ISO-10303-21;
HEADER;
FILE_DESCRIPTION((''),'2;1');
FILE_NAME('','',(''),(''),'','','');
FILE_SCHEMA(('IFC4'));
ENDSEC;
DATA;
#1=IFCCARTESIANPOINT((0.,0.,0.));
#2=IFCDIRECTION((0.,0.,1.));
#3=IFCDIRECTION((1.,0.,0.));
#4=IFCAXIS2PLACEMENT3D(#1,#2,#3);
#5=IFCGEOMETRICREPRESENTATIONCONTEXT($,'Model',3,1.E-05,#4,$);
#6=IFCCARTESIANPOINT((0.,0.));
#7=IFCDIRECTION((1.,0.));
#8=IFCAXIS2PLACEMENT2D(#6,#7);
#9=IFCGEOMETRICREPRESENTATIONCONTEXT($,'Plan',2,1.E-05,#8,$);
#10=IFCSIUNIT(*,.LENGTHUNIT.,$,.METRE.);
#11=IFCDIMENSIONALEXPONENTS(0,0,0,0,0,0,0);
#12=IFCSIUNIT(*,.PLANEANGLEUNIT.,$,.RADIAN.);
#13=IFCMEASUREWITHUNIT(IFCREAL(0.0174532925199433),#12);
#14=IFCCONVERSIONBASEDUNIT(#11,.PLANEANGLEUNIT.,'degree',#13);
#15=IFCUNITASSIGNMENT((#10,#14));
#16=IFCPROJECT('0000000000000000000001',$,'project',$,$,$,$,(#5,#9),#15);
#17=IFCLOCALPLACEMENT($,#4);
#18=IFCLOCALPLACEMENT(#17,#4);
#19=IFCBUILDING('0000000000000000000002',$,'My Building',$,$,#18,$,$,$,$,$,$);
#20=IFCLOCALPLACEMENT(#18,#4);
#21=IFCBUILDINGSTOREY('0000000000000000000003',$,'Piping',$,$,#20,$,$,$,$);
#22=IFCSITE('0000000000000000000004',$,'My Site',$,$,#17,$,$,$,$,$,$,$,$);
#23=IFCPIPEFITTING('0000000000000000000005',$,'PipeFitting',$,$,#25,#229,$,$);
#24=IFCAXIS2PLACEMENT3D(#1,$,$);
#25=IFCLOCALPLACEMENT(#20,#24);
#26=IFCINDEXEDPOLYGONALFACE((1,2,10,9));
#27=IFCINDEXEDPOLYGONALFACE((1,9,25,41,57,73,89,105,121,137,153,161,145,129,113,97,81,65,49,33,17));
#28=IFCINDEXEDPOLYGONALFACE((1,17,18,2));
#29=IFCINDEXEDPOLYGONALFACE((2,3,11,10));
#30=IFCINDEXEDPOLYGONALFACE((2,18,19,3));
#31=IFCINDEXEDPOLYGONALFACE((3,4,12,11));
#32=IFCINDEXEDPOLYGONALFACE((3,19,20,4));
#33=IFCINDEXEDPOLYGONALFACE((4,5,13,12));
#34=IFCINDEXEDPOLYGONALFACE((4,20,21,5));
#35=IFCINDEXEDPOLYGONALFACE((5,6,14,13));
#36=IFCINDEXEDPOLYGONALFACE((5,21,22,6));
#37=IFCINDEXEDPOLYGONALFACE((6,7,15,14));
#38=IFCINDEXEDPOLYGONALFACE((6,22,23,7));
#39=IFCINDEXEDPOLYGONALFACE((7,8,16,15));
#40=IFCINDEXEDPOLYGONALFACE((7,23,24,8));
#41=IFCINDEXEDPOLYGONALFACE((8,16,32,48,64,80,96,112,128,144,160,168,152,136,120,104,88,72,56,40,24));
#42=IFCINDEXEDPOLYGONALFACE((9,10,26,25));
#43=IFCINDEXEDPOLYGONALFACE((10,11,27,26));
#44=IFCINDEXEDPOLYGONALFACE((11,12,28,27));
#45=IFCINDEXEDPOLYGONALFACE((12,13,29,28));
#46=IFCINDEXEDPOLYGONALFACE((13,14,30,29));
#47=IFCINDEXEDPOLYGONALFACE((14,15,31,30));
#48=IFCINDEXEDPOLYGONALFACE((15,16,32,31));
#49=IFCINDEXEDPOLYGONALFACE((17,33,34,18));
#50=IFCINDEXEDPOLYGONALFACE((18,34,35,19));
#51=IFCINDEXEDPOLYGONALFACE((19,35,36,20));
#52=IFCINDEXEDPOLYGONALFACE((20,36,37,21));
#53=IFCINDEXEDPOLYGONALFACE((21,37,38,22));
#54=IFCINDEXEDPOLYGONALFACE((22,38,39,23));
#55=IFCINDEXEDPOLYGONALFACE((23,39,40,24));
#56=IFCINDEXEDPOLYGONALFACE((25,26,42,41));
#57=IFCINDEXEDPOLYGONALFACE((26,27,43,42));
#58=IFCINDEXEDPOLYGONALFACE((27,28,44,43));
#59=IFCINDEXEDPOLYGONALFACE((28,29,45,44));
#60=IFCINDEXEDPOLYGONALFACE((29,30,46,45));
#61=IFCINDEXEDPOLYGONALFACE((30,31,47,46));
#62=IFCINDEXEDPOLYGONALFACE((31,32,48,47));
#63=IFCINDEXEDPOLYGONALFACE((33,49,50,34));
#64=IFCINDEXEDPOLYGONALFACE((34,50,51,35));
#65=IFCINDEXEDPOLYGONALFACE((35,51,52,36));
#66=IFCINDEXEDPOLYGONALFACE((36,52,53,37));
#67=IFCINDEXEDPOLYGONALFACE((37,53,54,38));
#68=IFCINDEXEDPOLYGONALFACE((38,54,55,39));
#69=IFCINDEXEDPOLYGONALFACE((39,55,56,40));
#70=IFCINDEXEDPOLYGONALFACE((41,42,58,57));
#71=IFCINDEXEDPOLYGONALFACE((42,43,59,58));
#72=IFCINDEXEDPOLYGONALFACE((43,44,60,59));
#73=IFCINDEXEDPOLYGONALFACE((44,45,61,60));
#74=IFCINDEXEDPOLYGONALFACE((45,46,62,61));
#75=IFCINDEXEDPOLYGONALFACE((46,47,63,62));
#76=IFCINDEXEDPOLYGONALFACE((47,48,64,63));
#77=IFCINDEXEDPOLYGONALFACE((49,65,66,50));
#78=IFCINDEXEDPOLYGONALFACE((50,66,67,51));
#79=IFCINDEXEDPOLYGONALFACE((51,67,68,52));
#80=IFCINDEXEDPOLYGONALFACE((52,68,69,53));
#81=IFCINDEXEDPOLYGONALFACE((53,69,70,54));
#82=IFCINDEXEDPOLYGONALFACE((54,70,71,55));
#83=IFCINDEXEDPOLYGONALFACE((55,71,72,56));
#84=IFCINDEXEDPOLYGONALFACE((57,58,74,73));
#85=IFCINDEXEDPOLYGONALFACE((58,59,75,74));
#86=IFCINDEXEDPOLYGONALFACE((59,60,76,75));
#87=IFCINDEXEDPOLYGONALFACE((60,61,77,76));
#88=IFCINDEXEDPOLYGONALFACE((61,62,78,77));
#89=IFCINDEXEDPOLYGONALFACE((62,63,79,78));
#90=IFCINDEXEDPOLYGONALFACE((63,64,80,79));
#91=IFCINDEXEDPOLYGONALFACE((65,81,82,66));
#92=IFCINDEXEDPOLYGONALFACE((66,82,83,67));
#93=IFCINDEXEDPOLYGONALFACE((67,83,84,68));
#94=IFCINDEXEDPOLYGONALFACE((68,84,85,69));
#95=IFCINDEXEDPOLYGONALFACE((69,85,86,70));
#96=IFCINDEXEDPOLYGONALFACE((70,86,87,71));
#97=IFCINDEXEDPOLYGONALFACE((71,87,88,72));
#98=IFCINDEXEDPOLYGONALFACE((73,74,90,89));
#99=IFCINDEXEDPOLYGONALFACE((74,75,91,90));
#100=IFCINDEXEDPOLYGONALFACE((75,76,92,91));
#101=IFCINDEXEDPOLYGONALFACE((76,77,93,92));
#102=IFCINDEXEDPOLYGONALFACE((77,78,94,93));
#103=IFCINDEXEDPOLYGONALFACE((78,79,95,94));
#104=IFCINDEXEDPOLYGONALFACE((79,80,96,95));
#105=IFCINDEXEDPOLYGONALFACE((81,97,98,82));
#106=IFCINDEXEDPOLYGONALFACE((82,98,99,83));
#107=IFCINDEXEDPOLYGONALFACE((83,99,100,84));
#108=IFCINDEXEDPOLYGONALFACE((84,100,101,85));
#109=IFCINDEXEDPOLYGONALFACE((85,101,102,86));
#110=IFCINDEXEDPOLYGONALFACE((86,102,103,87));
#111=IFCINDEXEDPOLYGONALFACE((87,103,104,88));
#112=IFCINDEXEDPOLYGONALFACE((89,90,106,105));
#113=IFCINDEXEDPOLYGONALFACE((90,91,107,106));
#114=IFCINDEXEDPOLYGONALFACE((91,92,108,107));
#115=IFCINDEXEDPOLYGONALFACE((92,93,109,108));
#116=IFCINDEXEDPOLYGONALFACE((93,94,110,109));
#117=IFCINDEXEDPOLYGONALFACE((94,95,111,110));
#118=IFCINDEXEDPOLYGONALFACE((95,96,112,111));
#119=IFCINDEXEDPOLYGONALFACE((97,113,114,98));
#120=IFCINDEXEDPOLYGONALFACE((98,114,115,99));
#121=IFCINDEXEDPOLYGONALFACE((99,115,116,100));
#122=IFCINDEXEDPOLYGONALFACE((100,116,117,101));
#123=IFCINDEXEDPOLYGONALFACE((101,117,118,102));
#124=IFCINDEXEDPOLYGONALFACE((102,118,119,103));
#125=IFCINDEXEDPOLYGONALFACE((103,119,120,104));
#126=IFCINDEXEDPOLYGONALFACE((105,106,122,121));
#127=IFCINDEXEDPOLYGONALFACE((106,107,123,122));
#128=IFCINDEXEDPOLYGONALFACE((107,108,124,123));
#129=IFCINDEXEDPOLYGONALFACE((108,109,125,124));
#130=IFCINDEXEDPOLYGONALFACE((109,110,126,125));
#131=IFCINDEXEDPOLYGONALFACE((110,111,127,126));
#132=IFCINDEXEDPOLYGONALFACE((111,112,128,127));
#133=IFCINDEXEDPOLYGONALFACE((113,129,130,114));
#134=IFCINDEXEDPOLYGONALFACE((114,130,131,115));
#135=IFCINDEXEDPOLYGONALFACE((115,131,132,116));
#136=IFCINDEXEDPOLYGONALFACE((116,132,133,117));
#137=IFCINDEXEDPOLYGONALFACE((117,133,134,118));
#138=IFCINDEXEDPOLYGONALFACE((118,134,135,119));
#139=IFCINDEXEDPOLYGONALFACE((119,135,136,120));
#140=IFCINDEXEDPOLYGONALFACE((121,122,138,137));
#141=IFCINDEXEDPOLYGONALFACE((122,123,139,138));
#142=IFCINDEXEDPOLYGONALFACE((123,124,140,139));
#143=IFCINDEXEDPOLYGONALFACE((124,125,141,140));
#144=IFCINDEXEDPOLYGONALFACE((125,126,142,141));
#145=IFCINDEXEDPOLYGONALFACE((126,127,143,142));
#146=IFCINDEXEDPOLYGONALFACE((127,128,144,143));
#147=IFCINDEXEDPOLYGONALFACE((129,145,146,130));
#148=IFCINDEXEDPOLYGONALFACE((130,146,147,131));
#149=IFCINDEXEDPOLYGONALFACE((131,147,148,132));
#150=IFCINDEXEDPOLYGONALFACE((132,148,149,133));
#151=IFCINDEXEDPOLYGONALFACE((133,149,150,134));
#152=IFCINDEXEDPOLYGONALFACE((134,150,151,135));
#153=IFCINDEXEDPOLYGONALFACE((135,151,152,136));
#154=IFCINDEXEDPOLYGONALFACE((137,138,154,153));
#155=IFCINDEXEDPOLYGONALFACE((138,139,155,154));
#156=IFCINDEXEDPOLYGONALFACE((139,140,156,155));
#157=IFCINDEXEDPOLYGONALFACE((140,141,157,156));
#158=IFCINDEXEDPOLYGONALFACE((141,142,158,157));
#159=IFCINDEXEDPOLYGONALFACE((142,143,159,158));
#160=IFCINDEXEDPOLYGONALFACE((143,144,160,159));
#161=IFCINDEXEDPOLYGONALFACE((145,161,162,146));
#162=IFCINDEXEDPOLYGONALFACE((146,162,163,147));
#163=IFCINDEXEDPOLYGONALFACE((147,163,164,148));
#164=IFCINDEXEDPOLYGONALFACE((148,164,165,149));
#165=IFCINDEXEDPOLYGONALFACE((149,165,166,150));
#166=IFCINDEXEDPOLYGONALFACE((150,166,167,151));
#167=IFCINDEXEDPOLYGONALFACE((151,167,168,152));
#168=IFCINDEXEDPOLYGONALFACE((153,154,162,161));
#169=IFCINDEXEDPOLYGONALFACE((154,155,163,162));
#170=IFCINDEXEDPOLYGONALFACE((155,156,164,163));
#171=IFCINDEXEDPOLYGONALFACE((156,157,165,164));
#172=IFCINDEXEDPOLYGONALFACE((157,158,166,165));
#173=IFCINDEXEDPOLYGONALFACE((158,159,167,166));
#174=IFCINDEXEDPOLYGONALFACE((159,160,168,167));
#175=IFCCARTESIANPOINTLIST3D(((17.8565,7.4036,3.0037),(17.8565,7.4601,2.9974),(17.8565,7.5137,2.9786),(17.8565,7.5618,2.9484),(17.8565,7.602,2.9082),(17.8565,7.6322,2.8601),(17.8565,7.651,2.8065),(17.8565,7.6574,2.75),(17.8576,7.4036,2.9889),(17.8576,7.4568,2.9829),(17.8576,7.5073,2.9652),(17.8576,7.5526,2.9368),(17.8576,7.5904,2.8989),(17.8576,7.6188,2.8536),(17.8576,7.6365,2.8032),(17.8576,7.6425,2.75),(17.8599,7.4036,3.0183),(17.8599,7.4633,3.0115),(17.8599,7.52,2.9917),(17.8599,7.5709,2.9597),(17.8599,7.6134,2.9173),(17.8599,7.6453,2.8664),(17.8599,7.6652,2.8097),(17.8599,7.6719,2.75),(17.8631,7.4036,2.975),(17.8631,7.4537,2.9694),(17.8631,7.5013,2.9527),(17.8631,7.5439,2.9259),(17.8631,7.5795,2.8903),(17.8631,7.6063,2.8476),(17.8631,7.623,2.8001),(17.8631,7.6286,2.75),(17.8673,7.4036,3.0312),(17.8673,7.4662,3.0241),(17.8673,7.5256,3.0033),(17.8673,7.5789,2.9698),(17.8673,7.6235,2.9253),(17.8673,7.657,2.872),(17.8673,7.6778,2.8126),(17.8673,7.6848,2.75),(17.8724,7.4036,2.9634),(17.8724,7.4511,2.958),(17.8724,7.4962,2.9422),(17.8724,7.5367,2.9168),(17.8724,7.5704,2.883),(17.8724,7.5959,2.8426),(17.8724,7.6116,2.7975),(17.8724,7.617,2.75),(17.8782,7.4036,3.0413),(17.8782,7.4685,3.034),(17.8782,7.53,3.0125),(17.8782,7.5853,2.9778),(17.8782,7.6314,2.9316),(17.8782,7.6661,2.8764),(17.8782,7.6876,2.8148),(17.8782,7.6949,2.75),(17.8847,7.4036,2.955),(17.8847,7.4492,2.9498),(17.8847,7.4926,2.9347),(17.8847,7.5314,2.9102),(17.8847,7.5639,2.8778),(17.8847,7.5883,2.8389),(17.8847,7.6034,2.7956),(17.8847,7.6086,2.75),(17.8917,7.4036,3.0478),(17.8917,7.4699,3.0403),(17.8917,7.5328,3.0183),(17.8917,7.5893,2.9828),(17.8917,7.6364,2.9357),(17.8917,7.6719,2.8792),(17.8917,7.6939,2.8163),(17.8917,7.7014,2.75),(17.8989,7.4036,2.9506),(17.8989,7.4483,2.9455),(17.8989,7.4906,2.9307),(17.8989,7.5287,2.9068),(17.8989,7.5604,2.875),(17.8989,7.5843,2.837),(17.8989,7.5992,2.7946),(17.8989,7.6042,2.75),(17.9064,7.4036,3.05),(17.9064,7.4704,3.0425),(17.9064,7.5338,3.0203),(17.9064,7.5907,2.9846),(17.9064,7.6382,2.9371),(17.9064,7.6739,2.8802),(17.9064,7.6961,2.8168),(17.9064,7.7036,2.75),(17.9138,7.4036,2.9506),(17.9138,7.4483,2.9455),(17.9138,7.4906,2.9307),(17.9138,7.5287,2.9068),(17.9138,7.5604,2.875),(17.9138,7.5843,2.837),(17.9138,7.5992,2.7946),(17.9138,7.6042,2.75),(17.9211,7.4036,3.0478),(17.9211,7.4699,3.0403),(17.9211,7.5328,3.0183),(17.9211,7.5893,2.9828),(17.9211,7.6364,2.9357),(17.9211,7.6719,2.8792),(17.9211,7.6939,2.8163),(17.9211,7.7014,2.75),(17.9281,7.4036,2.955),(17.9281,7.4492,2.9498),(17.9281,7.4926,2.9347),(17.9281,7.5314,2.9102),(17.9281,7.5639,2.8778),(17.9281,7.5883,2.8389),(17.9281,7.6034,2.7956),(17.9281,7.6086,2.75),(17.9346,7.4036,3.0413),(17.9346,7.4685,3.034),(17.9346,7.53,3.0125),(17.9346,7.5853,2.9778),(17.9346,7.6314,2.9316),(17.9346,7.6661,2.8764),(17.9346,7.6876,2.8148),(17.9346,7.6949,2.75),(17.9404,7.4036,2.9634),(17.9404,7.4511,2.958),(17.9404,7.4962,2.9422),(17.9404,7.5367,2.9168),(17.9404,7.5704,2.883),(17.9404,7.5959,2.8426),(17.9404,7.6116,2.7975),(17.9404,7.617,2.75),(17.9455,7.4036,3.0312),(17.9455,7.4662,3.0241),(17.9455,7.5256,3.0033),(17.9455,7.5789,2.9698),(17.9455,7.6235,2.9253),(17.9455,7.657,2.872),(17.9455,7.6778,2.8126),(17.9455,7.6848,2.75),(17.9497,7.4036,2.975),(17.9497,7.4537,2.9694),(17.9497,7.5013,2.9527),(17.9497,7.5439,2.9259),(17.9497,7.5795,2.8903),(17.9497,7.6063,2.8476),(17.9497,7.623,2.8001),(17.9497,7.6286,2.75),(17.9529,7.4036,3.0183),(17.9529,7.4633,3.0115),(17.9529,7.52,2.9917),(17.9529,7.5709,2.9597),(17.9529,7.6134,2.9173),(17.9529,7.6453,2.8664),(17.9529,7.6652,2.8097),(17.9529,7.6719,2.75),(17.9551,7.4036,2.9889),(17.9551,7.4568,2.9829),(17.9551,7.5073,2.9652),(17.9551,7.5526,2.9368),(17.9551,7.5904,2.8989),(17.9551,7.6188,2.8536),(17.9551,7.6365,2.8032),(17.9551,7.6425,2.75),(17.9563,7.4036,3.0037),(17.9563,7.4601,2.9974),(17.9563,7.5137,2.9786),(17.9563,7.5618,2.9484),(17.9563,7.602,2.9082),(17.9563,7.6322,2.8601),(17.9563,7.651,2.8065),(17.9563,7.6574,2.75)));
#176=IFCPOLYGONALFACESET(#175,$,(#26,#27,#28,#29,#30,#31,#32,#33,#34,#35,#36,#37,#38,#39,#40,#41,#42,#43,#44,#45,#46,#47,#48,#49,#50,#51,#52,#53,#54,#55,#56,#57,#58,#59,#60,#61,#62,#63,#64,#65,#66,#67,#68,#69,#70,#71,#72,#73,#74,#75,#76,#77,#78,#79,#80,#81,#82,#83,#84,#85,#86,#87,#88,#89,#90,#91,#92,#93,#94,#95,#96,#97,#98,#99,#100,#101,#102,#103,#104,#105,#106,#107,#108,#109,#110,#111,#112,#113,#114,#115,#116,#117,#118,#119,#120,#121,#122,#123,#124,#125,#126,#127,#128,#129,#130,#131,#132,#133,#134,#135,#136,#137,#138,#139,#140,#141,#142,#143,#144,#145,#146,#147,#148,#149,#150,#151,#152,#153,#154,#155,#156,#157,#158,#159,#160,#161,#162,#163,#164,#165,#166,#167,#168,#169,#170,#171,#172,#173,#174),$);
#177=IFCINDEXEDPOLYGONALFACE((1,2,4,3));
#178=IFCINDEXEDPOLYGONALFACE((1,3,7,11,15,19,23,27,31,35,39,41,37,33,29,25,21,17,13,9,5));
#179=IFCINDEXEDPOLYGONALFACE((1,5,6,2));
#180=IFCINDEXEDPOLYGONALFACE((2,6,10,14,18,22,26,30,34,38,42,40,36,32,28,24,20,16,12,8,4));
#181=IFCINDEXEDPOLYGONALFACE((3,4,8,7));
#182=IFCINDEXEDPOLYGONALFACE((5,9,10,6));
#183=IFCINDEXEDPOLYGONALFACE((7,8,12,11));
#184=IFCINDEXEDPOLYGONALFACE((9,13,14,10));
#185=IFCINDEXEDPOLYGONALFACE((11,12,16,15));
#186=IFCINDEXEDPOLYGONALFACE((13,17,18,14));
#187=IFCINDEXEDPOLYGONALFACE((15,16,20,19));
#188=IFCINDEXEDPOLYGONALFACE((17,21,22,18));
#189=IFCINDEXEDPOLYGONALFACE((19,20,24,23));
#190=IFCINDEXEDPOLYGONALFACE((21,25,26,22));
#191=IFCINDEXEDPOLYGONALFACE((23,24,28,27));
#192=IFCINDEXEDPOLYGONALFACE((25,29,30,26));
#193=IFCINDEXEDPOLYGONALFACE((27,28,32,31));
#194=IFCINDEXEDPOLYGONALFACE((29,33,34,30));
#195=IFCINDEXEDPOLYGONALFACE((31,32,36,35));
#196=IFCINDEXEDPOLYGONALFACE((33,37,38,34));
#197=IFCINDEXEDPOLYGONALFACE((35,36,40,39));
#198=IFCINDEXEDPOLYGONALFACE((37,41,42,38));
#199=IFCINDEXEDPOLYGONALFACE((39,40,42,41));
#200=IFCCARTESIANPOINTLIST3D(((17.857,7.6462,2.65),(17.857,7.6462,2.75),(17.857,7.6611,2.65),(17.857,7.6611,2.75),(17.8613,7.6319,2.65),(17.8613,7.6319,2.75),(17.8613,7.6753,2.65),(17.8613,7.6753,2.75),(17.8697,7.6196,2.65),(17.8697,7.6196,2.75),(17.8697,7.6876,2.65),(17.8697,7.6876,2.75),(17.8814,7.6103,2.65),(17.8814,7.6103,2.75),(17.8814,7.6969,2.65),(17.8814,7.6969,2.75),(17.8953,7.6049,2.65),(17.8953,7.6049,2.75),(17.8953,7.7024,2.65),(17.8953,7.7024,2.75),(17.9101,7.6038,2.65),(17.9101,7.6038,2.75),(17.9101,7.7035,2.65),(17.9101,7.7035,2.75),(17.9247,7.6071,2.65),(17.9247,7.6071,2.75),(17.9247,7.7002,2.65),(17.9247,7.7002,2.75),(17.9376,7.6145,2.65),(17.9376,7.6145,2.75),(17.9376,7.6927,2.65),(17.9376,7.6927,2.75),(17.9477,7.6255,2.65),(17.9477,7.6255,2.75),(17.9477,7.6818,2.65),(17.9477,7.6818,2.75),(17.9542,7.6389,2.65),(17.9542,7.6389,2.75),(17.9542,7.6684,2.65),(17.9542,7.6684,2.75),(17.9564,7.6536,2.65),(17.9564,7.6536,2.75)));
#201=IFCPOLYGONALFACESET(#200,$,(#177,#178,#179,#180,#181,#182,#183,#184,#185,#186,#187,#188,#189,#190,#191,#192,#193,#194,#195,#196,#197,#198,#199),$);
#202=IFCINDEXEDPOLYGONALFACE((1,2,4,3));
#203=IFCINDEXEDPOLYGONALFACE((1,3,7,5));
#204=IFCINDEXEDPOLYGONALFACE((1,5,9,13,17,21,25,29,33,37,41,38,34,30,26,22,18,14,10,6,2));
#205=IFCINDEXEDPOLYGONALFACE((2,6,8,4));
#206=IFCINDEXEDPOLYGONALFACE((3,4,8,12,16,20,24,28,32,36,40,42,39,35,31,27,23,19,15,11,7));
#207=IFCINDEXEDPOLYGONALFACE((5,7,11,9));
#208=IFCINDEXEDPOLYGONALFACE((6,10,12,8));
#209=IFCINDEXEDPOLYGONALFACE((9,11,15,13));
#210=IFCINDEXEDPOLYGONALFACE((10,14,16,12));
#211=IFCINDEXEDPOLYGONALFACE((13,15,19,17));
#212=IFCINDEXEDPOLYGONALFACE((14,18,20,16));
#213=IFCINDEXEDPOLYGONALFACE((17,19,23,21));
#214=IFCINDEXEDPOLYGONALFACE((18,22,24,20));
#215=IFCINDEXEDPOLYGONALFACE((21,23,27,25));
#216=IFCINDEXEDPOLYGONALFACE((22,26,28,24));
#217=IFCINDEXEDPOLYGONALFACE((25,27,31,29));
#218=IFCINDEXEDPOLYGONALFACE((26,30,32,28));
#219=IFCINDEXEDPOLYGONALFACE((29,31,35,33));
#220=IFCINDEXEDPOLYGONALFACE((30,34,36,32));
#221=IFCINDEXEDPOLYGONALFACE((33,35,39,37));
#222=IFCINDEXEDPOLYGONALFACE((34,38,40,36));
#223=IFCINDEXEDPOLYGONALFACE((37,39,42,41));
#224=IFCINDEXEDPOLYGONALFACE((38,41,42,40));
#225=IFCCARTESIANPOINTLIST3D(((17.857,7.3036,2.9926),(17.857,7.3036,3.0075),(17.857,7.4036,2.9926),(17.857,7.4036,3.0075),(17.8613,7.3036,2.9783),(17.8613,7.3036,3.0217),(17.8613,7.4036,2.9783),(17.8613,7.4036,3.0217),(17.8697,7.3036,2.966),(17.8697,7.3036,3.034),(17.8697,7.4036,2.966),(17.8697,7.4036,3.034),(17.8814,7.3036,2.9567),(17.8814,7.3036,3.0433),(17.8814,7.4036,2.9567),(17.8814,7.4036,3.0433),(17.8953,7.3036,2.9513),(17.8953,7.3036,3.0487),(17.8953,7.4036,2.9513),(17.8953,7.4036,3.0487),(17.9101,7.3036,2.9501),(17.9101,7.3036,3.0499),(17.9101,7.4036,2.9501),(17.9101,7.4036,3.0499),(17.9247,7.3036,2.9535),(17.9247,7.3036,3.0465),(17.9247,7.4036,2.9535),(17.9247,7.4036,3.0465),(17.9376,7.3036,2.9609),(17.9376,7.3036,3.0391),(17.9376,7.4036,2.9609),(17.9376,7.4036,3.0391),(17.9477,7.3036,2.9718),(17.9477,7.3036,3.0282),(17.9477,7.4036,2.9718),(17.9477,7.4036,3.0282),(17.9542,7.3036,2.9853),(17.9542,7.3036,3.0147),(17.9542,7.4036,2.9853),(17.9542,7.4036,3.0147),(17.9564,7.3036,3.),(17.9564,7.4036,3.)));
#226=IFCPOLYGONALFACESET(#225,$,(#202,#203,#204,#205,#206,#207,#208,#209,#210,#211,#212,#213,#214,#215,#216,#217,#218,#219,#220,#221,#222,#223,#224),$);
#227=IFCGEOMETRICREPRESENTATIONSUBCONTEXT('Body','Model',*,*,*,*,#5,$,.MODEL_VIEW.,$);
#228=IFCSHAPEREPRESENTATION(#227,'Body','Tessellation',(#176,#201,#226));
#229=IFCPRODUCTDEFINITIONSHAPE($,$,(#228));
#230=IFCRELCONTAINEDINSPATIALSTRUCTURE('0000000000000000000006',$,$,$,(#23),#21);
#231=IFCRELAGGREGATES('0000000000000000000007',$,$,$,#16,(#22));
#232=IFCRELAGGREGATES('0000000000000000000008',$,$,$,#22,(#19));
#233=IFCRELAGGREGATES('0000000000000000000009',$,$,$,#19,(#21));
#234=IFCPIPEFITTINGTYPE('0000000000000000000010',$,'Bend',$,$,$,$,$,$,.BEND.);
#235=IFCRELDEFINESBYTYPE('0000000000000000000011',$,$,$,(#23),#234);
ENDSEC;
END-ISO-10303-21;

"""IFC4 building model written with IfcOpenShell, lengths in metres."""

from ifc_helpers import new_model, entity, si_unit, converted_unit, frame, origin_with_axes, origin_2d_with_axis, place, context, subcontext, project, spatial, circle, extrude, source, transform, mapped, type_object, type_shapes, element, save


model = new_model("IFC4")

# Units and contexts
model_context = context("Model", 3, precision=1e-05, world=origin_with_axes())
plan_context = context("Plan", 2, precision=1e-05, world=origin_2d_with_axis())
body_context = subcontext(model_context, "Body", "Model", "MODEL_VIEW")
ifc_project = project(units=[si_unit("LENGTHUNIT", "METRE"), converted_unit("PLANEANGLEUNIT", "degree", entity("IfcReal", 0.0174532925199433), si_unit("PLANEANGLEUNIT", "RADIAN"), dimensions=[0, 0, 0, 0, 0, 0, 0])], contexts=[model_context, plan_context])

# Site, building, storey
site_placement = place(None, origin_with_axes())
site = spatial("IfcSite", under=ifc_project, at=site_placement, Name="My Site")
building_placement = place(site_placement, origin_with_axes())
building = spatial("IfcBuilding", under=site, at=building_placement, Name="My Building")
storey_placement = place(building_placement, origin_with_axes())
storey = spatial("IfcBuildingStorey", under=building, at=storey_placement, Name="Piping")

# Pipe fitting
pipe_fitting_type = type_object("IfcPipeFittingType", Name="Bend", PredefinedType="BEND")
shared_shape = source(origin_with_axes(), body_context, "Body", "SolidModel", [
    entity("IfcSweptDiskSolid", entity("IfcIndexedPolyCurve", entity("IfcCartesianPointList3D", [[0.0, 0.0, -0.1], [0.0, 0.0732, -0.2768], [0.0, 0.25, -0.35]]), [entity("IfcArcIndex", [1, 2, 3])]), 0.05),
    extrude(circle(Radius=0.05), origin_with_axes(), (0.0, 0.0, -1.0), 0.1),
    extrude(circle(Radius=0.05), frame((0.0, 0.25, -0.35), z_axis=(0.0, 1.0, 0.0), x_axis=(1.0, 0.0, 0.0)), (0.0, 0.0, 1.0), 0.1),
])
type_shapes(pipe_fitting_type, [shared_shape])
for number, where, z_axis, x_axis, name in (
    (1, (17.9064, 7.6536, 2.65), (0.0, 0.0, -1.0), (1.0, 0.0, 0.0), "PipeFitting"),
):
    element("IfcPipeFitting", number, at=place(storey_placement, frame(where, z_axis=z_axis, x_axis=x_axis)), inside=storey, type_object=pipe_fitting_type, Name=name, context=body_context, shape_type="MappedRepresentation", body=[
        mapped(shared_shape, transform((0.0, 0.0, 0.0), x_axis=(1.0, 0.0, 0.0), y_axis=(0.0, 1.0, 0.0), z_axis=(0.0, 0.0, 1.0), scale=1.0)),
    ])

save(model, "model.ifc")
